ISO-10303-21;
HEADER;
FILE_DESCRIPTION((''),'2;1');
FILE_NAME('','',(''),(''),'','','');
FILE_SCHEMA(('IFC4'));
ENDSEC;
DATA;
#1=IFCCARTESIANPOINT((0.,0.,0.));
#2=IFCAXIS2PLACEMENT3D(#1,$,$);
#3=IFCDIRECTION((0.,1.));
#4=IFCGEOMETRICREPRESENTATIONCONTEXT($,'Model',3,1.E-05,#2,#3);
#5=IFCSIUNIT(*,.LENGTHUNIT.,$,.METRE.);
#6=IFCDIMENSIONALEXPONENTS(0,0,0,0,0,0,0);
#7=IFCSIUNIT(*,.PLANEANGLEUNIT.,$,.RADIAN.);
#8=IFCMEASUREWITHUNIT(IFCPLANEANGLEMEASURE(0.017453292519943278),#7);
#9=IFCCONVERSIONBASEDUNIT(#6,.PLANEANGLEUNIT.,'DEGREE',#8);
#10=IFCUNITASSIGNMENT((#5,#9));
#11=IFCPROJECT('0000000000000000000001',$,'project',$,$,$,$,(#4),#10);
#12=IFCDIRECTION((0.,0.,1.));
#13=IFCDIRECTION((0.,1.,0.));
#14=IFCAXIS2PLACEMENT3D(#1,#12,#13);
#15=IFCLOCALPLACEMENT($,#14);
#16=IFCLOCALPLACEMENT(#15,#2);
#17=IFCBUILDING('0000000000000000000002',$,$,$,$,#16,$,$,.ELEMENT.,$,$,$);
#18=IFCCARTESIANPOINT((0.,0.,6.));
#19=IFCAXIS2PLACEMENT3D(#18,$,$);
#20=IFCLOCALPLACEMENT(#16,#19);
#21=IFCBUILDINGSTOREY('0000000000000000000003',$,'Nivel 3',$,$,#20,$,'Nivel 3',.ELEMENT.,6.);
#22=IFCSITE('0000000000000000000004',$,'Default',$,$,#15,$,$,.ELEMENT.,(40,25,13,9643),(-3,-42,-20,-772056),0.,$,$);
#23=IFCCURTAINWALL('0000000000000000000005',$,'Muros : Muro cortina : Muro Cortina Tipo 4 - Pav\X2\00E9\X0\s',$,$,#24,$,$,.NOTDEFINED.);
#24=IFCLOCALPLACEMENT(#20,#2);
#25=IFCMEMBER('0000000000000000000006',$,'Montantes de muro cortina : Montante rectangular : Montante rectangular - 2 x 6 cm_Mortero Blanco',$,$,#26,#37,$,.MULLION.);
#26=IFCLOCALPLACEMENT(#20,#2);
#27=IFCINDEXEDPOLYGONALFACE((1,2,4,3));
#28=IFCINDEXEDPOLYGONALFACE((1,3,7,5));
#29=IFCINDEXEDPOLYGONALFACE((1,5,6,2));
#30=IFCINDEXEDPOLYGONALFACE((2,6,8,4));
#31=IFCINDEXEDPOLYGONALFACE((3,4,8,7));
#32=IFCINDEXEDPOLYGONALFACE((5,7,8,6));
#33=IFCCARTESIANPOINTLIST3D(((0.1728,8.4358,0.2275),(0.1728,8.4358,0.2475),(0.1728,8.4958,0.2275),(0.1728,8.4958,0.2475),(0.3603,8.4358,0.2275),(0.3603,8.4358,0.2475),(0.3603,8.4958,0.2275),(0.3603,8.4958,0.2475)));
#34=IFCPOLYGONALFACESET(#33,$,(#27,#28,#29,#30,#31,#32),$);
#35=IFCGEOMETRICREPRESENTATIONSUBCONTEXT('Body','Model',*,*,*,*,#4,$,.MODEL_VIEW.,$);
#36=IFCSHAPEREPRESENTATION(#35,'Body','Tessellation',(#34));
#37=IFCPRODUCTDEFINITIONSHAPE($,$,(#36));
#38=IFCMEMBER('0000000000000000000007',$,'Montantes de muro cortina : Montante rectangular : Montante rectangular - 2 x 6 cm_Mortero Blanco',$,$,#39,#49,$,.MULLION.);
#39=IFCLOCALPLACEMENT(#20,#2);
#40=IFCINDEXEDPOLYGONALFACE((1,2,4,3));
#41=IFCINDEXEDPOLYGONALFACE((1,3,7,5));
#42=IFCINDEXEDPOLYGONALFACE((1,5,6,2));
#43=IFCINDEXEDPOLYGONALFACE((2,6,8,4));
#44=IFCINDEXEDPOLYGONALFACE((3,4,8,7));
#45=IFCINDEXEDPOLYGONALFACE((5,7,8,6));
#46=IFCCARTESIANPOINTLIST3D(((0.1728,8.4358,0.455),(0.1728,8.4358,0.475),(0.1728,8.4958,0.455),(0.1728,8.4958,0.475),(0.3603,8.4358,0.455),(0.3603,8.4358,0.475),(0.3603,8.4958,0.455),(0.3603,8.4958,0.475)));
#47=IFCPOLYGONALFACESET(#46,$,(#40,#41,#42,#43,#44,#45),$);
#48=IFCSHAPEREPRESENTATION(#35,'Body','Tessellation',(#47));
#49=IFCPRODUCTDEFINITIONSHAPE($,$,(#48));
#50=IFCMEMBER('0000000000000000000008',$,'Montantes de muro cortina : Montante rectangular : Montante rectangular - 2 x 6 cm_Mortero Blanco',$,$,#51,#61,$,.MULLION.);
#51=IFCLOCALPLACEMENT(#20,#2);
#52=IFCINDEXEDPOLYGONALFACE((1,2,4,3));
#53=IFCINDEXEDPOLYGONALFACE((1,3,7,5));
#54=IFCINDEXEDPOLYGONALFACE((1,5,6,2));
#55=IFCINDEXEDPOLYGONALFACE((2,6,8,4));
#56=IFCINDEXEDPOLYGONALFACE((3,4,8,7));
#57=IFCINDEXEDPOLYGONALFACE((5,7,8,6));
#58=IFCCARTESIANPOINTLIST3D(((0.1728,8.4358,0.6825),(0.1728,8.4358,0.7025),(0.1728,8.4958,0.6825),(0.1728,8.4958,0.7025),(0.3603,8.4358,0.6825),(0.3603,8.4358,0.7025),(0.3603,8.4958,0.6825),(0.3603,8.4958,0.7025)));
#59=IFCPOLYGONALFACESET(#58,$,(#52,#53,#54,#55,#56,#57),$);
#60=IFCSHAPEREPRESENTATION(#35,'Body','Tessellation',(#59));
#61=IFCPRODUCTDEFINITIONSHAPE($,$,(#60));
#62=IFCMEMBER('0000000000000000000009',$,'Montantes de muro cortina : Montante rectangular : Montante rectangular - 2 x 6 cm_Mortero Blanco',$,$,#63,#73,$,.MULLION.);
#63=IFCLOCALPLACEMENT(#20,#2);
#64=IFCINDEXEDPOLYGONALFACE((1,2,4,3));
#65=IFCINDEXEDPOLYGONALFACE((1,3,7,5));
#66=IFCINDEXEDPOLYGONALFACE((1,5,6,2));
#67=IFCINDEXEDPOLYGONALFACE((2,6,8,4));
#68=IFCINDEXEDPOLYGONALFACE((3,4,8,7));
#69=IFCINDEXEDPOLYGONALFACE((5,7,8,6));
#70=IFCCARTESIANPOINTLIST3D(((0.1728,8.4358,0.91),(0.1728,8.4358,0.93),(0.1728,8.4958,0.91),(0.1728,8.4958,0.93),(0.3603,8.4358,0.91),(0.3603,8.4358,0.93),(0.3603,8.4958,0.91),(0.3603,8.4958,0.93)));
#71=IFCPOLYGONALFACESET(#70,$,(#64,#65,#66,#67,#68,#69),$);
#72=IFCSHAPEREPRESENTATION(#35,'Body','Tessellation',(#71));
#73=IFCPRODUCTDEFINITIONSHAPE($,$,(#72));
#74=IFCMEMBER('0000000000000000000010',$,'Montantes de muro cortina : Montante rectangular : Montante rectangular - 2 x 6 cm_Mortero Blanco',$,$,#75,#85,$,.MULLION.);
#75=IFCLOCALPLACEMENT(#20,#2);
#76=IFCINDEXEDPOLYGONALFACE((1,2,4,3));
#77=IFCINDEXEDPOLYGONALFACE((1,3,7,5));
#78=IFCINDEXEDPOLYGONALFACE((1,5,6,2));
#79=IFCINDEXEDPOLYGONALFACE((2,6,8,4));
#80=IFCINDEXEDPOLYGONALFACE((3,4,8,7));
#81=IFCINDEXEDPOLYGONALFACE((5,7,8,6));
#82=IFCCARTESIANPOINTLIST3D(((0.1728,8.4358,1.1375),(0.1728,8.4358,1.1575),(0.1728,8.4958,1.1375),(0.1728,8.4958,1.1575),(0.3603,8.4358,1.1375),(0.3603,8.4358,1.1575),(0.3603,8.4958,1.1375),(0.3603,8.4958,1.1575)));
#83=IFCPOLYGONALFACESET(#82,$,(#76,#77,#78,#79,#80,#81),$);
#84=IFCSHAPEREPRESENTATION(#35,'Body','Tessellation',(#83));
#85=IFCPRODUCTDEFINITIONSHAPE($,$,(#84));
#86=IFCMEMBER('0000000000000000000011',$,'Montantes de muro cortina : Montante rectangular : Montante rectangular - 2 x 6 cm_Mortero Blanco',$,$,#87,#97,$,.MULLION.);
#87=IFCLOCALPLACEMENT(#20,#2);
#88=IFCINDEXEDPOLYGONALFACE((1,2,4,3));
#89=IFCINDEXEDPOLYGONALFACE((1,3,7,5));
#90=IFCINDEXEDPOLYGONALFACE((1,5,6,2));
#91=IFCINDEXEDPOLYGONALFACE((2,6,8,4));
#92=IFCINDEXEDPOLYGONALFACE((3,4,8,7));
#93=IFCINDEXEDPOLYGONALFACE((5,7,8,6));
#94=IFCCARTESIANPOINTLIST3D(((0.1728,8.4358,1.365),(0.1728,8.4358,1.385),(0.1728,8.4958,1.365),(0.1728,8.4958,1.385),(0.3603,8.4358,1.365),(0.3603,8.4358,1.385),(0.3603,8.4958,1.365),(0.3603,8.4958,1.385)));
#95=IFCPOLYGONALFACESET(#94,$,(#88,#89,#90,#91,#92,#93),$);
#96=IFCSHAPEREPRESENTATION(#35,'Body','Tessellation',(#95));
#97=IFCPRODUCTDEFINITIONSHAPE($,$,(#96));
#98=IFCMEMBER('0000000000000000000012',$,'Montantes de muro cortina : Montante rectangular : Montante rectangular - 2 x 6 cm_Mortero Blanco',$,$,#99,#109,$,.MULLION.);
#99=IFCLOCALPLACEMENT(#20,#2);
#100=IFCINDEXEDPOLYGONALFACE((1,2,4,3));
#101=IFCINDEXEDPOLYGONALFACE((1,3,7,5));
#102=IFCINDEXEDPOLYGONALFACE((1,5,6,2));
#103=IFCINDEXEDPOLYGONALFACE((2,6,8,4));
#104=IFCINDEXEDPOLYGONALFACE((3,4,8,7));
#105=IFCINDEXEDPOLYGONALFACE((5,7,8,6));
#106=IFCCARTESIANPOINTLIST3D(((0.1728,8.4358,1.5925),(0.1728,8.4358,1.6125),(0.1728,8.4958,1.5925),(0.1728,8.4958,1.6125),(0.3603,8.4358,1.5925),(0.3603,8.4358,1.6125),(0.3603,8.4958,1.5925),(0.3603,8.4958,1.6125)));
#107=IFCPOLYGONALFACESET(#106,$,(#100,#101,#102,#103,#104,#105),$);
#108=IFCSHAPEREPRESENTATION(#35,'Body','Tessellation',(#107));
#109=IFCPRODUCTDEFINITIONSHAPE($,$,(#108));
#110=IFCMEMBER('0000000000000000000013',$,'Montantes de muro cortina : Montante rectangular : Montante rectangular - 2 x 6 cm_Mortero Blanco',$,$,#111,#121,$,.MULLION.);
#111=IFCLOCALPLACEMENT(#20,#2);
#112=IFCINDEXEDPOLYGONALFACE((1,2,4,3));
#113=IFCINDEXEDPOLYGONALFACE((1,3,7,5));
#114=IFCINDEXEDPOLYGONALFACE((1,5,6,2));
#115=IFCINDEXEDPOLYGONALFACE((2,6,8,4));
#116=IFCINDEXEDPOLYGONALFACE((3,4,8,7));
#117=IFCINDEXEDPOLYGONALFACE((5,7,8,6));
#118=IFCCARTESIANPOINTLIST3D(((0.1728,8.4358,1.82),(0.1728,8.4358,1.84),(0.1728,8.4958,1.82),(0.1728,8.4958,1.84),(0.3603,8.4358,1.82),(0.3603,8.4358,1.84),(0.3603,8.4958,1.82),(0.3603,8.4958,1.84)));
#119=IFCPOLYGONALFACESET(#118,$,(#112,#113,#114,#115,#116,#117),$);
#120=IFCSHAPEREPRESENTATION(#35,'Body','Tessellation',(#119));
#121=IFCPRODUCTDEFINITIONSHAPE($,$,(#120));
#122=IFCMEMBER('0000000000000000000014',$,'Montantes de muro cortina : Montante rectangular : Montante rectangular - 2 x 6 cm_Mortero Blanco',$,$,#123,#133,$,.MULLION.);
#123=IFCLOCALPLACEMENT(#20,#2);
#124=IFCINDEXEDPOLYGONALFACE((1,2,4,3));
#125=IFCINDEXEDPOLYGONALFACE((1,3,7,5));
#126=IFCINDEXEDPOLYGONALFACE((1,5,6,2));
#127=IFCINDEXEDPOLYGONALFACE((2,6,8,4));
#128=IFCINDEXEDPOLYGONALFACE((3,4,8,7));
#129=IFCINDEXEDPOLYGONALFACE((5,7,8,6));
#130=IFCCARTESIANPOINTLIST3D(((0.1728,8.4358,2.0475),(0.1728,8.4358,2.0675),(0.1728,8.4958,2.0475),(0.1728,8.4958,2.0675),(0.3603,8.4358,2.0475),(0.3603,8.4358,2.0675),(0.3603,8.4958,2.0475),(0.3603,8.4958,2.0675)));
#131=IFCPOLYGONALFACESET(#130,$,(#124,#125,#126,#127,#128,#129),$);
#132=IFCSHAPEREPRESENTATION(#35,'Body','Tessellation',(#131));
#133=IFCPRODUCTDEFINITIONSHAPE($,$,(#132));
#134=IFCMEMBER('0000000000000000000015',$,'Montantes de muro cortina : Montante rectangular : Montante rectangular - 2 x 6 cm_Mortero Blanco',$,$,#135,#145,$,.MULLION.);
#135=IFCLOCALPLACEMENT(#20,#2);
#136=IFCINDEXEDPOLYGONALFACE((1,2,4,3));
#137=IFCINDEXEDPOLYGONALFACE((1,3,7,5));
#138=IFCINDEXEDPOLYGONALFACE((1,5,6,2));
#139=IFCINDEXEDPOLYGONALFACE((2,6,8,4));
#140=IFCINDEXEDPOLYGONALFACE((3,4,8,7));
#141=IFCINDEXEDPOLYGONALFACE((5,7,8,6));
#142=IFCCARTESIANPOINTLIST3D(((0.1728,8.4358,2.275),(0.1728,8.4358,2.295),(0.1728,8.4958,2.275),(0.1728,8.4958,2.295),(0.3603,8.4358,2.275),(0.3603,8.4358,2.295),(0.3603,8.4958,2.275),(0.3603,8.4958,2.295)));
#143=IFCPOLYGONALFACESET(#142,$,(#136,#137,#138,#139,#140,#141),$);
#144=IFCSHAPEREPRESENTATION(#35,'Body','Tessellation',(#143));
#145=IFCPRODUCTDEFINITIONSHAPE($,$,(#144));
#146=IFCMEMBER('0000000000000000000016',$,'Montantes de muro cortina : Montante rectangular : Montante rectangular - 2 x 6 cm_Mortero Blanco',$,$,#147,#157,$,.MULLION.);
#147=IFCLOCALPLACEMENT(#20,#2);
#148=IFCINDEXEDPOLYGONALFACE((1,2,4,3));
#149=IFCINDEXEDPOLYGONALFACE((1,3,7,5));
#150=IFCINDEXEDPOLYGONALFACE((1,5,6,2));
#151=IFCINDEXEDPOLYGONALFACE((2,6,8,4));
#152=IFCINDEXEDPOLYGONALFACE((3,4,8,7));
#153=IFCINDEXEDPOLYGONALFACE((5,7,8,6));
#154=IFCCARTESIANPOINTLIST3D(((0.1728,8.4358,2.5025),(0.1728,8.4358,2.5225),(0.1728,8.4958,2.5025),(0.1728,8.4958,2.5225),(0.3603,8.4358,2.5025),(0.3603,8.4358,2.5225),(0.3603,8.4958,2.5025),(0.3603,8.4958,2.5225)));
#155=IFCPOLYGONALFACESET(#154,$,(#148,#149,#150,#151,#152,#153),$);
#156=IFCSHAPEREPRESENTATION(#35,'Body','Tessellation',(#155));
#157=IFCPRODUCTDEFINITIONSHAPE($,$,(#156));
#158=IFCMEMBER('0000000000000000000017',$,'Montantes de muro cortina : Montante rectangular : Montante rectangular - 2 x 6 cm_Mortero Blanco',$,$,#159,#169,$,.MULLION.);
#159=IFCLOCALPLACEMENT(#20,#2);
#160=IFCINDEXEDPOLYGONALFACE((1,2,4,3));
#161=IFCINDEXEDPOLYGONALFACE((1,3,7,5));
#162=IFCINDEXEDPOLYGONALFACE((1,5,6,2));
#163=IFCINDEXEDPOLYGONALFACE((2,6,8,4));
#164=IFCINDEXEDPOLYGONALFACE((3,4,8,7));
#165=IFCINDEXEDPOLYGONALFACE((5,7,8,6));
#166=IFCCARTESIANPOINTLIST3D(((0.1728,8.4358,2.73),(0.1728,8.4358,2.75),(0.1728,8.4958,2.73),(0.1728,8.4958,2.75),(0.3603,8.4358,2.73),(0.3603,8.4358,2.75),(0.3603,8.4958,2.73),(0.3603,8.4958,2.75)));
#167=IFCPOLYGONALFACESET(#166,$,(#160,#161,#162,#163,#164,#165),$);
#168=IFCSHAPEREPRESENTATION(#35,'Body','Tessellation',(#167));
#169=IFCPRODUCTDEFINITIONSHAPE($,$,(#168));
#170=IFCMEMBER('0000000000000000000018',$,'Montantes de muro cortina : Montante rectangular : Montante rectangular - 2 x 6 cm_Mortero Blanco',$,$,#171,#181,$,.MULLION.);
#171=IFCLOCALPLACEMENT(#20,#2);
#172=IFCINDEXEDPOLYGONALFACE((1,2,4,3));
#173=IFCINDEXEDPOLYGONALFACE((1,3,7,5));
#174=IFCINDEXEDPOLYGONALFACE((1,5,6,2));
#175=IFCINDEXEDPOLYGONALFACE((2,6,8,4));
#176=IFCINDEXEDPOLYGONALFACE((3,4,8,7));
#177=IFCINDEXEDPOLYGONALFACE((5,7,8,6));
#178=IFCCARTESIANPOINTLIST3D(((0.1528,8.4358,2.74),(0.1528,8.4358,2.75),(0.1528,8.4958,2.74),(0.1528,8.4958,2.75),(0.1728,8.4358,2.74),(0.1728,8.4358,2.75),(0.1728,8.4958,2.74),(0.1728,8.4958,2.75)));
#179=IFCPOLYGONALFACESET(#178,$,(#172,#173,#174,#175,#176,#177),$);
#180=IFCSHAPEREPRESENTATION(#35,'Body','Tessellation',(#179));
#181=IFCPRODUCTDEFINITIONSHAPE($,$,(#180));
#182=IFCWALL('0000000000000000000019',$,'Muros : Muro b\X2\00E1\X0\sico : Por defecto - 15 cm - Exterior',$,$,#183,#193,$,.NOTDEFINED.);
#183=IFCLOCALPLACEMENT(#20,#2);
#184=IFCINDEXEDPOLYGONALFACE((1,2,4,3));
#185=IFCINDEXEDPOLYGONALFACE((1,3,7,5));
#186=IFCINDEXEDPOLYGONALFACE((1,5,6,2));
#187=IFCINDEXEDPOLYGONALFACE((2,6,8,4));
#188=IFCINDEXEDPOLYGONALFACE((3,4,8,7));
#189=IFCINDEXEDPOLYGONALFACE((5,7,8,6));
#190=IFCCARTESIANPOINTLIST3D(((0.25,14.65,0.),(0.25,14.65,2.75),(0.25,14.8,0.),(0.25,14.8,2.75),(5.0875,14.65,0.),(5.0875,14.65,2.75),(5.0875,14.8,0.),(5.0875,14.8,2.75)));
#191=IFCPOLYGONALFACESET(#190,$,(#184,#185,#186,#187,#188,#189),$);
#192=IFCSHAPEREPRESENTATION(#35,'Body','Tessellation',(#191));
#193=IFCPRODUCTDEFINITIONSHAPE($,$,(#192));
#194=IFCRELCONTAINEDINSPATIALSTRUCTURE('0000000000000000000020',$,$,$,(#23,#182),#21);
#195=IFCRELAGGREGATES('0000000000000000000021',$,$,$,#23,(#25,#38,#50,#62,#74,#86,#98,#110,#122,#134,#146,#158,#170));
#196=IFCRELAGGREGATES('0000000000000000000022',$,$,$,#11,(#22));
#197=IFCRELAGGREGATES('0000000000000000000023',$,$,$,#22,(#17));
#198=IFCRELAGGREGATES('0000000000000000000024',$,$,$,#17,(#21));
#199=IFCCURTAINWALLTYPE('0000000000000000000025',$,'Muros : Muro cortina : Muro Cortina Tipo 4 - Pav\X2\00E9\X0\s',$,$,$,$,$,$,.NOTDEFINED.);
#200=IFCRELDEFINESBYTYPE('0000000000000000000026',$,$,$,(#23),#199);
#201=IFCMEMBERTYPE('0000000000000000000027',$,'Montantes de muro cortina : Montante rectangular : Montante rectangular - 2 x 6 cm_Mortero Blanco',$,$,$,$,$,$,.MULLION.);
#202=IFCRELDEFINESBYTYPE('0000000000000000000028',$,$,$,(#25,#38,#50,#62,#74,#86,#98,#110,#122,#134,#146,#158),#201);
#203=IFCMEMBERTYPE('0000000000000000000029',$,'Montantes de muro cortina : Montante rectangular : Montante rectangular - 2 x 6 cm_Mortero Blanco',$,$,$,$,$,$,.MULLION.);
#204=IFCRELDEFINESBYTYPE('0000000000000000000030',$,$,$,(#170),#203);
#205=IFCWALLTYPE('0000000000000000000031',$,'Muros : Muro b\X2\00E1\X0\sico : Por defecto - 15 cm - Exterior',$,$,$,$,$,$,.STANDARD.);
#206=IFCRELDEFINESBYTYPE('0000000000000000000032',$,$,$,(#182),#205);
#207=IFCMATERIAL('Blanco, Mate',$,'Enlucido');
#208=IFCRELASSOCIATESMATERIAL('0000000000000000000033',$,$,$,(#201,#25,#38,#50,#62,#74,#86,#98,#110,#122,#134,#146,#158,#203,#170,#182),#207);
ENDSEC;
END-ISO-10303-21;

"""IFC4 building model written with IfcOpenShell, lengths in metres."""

from ifc_helpers import new_model, entity, si_unit, converted_unit, direction, frame, origin, place, context, subcontext, project, spatial, indexed_curve, outline, extrude, source, transform, mapped, material, type_object, type_shapes, element, aggregate, save


model = new_model("IFC4")

# Units and contexts
model_context = context("Model", 3, precision=1e-05, world=origin(), true_north=direction((0.0, 1.0)))
body_context = subcontext(model_context, "Body", "Model", "MODEL_VIEW")
ifc_project = project(units=[si_unit("LENGTHUNIT", "METRE"), converted_unit("PLANEANGLEUNIT", "DEGREE", entity("IfcPlaneAngleMeasure", 0.017453292519943278), si_unit("PLANEANGLEUNIT", "RADIAN"), dimensions=[0, 0, 0, 0, 0, 0, 0])], contexts=[model_context])

# Site, building, storey
site_placement = place(None, frame((0.0, 0.0, 0.0), z_axis=(0.0, 0.0, 1.0), x_axis=(0.0, 1.0, 0.0)))
site = spatial("IfcSite", under=ifc_project, at=site_placement, Name="Default", CompositionType="ELEMENT", RefLatitude=(40, 25, 13, 9643), RefLongitude=(-3, -42, -20, -772056), RefElevation=0.0)
building_placement = place(site_placement, origin())
building = spatial("IfcBuilding", under=site, at=building_placement, CompositionType="ELEMENT")
storey_placement = place(building_placement, frame((0.0, 0.0, 6.0)))
storey = spatial("IfcBuildingStorey", under=building, at=storey_placement, Name="Nivel 3", LongName="Nivel 3", CompositionType="ELEMENT", Elevation=6.0)

# Curtain wall, members
curtain_wall_type = type_object("IfcCurtainWallType", Name="Muros : Muro cortina : Muro Cortina Tipo 4 - Pavés", PredefinedType="NOTDEFINED")
curtain_wall_placement = place(storey_placement, frame((0.0, 0.0, -6.0)))
curtain_wall = element("IfcCurtainWall", 1, at=curtain_wall_placement, inside=storey, type_object=curtain_wall_type, Name="Muros : Muro cortina : Muro Cortina Tipo 4 - Pavés", PredefinedType="NOTDEFINED")
ifc_material_1 = material(Name="Blanco, Mate", Category="Enlucido")
member_type_1 = type_object("IfcMemberType", Name="Montantes de muro cortina : Montante rectangular : Montante rectangular - 2 x 6 cm_Mortero Blanco", PredefinedType="MULLION", material=ifc_material_1)
shared_shape_1 = source(origin(), body_context, "Body", "SweptSolid", [
    extrude(outline(indexed_curve([(-0.01, -0.03), (0.01, -0.03), (0.01, 0.03), (-0.01, 0.03), (-0.01, -0.03)], self_intersect=False)), frame((0.0, 0.0, -0.1875), z_axis=(0.0, 0.0, 1.0), x_axis=(-1.0, 0.0, 0.0)), (0.0, 0.0, 1.0), 0.1875),
])
type_shapes(member_type_1, [shared_shape_1])
member_1_placement = place(curtain_wall_placement, frame((0.1728, 8.4658, 6.2375), z_axis=(-1.0, 0.0, 0.0), x_axis=(0.0, 0.0, 1.0)))
member_1 = element("IfcMember", 2, at=member_1_placement, type_object=member_type_1, material=ifc_material_1, Name="Montantes de muro cortina : Montante rectangular : Montante rectangular - 2 x 6 cm_Mortero Blanco", PredefinedType="MULLION", context=body_context, shape_type="MappedRepresentation", body=[
    mapped(shared_shape_1, transform((0.0, 0.0, 0.0), scale=1.0)),
])
member_2_placement = place(curtain_wall_placement, frame((0.1728, 8.4658, 6.465), z_axis=(-1.0, 0.0, 0.0), x_axis=(0.0, 0.0, 1.0)))
member_2 = element("IfcMember", 3, at=member_2_placement, type_object=member_type_1, material=ifc_material_1, Name="Montantes de muro cortina : Montante rectangular : Montante rectangular - 2 x 6 cm_Mortero Blanco", PredefinedType="MULLION", context=body_context, shape_type="MappedRepresentation", body=[
    mapped(shared_shape_1, transform((0.0, 0.0, 0.0), scale=1.0)),
])
member_3_placement = place(curtain_wall_placement, frame((0.1728, 8.4658, 6.6925), z_axis=(-1.0, 0.0, 0.0), x_axis=(0.0, 0.0, 1.0)))
member_3 = element("IfcMember", 4, at=member_3_placement, type_object=member_type_1, material=ifc_material_1, Name="Montantes de muro cortina : Montante rectangular : Montante rectangular - 2 x 6 cm_Mortero Blanco", PredefinedType="MULLION", context=body_context, shape_type="MappedRepresentation", body=[
    mapped(shared_shape_1, transform((0.0, 0.0, 0.0), scale=1.0)),
])
member_4_placement = place(curtain_wall_placement, frame((0.1728, 8.4658, 6.92), z_axis=(-1.0, 0.0, 0.0), x_axis=(0.0, 0.0, 1.0)))
member_4 = element("IfcMember", 5, at=member_4_placement, type_object=member_type_1, material=ifc_material_1, Name="Montantes de muro cortina : Montante rectangular : Montante rectangular - 2 x 6 cm_Mortero Blanco", PredefinedType="MULLION", context=body_context, shape_type="MappedRepresentation", body=[
    mapped(shared_shape_1, transform((0.0, 0.0, 0.0), scale=1.0)),
])
member_5_placement = place(curtain_wall_placement, frame((0.1728, 8.4658, 7.1475), z_axis=(-1.0, 0.0, 0.0), x_axis=(0.0, 0.0, 1.0)))
member_5 = element("IfcMember", 6, at=member_5_placement, type_object=member_type_1, material=ifc_material_1, Name="Montantes de muro cortina : Montante rectangular : Montante rectangular - 2 x 6 cm_Mortero Blanco", PredefinedType="MULLION", context=body_context, shape_type="MappedRepresentation", body=[
    mapped(shared_shape_1, transform((0.0, 0.0, 0.0), scale=1.0)),
])
member_6_placement = place(curtain_wall_placement, frame((0.1728, 8.4658, 7.375), z_axis=(-1.0, 0.0, 0.0), x_axis=(0.0, 0.0, 1.0)))
member_6 = element("IfcMember", 7, at=member_6_placement, type_object=member_type_1, material=ifc_material_1, Name="Montantes de muro cortina : Montante rectangular : Montante rectangular - 2 x 6 cm_Mortero Blanco", PredefinedType="MULLION", context=body_context, shape_type="MappedRepresentation", body=[
    mapped(shared_shape_1, transform((0.0, 0.0, 0.0), scale=1.0)),
])
member_7_placement = place(curtain_wall_placement, frame((0.1728, 8.4658, 7.6025), z_axis=(-1.0, 0.0, 0.0), x_axis=(0.0, 0.0, 1.0)))
member_7 = element("IfcMember", 8, at=member_7_placement, type_object=member_type_1, material=ifc_material_1, Name="Montantes de muro cortina : Montante rectangular : Montante rectangular - 2 x 6 cm_Mortero Blanco", PredefinedType="MULLION", context=body_context, shape_type="MappedRepresentation", body=[
    mapped(shared_shape_1, transform((0.0, 0.0, 0.0), scale=1.0)),
])
member_8_placement = place(curtain_wall_placement, frame((0.1728, 8.4658, 7.83), z_axis=(-1.0, 0.0, 0.0), x_axis=(0.0, 0.0, 1.0)))
member_8 = element("IfcMember", 9, at=member_8_placement, type_object=member_type_1, material=ifc_material_1, Name="Montantes de muro cortina : Montante rectangular : Montante rectangular - 2 x 6 cm_Mortero Blanco", PredefinedType="MULLION", context=body_context, shape_type="MappedRepresentation", body=[
    mapped(shared_shape_1, transform((0.0, 0.0, 0.0), scale=1.0)),
])
member_9_placement = place(curtain_wall_placement, frame((0.1728, 8.4658, 8.0575), z_axis=(-1.0, 0.0, 0.0), x_axis=(0.0, 0.0, 1.0)))
member_9 = element("IfcMember", 10, at=member_9_placement, type_object=member_type_1, material=ifc_material_1, Name="Montantes de muro cortina : Montante rectangular : Montante rectangular - 2 x 6 cm_Mortero Blanco", PredefinedType="MULLION", context=body_context, shape_type="MappedRepresentation", body=[
    mapped(shared_shape_1, transform((0.0, 0.0, 0.0), scale=1.0)),
])
member_10_placement = place(curtain_wall_placement, frame((0.1728, 8.4658, 8.285), z_axis=(-1.0, 0.0, 0.0), x_axis=(0.0, 0.0, 1.0)))
member_10 = element("IfcMember", 11, at=member_10_placement, type_object=member_type_1, material=ifc_material_1, Name="Montantes de muro cortina : Montante rectangular : Montante rectangular - 2 x 6 cm_Mortero Blanco", PredefinedType="MULLION", context=body_context, shape_type="MappedRepresentation", body=[
    mapped(shared_shape_1, transform((0.0, 0.0, 0.0), scale=1.0)),
])
member_11_placement = place(curtain_wall_placement, frame((0.1728, 8.4658, 8.5125), z_axis=(-1.0, 0.0, 0.0), x_axis=(0.0, 0.0, 1.0)))
member_11 = element("IfcMember", 12, at=member_11_placement, type_object=member_type_1, material=ifc_material_1, Name="Montantes de muro cortina : Montante rectangular : Montante rectangular - 2 x 6 cm_Mortero Blanco", PredefinedType="MULLION", context=body_context, shape_type="MappedRepresentation", body=[
    mapped(shared_shape_1, transform((0.0, 0.0, 0.0), scale=1.0)),
])
member_12_placement = place(curtain_wall_placement, frame((0.1728, 8.4658, 8.74), z_axis=(-1.0, 0.0, 0.0), x_axis=(0.0, 0.0, 1.0)))
member_12 = element("IfcMember", 13, at=member_12_placement, type_object=member_type_1, material=ifc_material_1, Name="Montantes de muro cortina : Montante rectangular : Montante rectangular - 2 x 6 cm_Mortero Blanco", PredefinedType="MULLION", context=body_context, shape_type="MappedRepresentation", body=[
    mapped(shared_shape_1, transform((0.0, 0.0, 0.0), scale=1.0)),
])
member_type_2 = type_object("IfcMemberType", Name="Montantes de muro cortina : Montante rectangular : Montante rectangular - 2 x 6 cm_Mortero Blanco", PredefinedType="MULLION", material=ifc_material_1)
shared_shape_2 = source(origin(), body_context, "Body", "SweptSolid", [
    extrude(outline(indexed_curve([(-0.01, -0.03), (0.01, -0.03), (0.01, 0.03), (-0.01, 0.03), (-0.01, -0.03)], self_intersect=False)), frame((-0.01, 0.0, -0.01), z_axis=(0.0, 0.0, 1.0), x_axis=(-1.0, 0.0, 0.0)), (0.0, 0.0, 1.0), 0.01),
])
type_shapes(member_type_2, [shared_shape_2])
member_13_placement = place(curtain_wall_placement, frame((0.1528, 8.4658, 8.74), z_axis=(0.0, 0.0, -1.0), x_axis=(-1.0, 0.0, 0.0)))
member_13 = element("IfcMember", 14, at=member_13_placement, type_object=member_type_2, material=ifc_material_1, Name="Montantes de muro cortina : Montante rectangular : Montante rectangular - 2 x 6 cm_Mortero Blanco", PredefinedType="MULLION", context=body_context, shape_type="MappedRepresentation", body=[
    mapped(shared_shape_2, transform((0.0, 0.0, 0.0), scale=1.0)),
])
aggregate(curtain_wall, [member_1, member_2, member_3, member_4, member_5, member_6, member_7, member_8, member_9, member_10, member_11, member_12, member_13])

# Wall
wall_type_1 = type_object("IfcWallType", Name="Muros : Muro básico : Por defecto - 15 cm - Exterior", PredefinedType="STANDARD")
wall_1_placement = place(storey_placement, frame((0.25, 14.725, 0.0)))
element("IfcWall", 15, at=wall_1_placement, inside=storey, type_object=wall_type_1, material=ifc_material_1, Name="Muros : Muro básico : Por defecto - 15 cm - Exterior", PredefinedType="NOTDEFINED", context=body_context, shape_type="SweptSolid", body=[
    extrude(outline(indexed_curve([(4.8375, 0.075), (0.0, 0.075), (0.0, -0.075), (4.8375, -0.075), (4.8375, 0.075)], self_intersect=False)), origin(), (0.0, 0.0, 1.0), 2.75),
])

save(model, "model.ifc")
